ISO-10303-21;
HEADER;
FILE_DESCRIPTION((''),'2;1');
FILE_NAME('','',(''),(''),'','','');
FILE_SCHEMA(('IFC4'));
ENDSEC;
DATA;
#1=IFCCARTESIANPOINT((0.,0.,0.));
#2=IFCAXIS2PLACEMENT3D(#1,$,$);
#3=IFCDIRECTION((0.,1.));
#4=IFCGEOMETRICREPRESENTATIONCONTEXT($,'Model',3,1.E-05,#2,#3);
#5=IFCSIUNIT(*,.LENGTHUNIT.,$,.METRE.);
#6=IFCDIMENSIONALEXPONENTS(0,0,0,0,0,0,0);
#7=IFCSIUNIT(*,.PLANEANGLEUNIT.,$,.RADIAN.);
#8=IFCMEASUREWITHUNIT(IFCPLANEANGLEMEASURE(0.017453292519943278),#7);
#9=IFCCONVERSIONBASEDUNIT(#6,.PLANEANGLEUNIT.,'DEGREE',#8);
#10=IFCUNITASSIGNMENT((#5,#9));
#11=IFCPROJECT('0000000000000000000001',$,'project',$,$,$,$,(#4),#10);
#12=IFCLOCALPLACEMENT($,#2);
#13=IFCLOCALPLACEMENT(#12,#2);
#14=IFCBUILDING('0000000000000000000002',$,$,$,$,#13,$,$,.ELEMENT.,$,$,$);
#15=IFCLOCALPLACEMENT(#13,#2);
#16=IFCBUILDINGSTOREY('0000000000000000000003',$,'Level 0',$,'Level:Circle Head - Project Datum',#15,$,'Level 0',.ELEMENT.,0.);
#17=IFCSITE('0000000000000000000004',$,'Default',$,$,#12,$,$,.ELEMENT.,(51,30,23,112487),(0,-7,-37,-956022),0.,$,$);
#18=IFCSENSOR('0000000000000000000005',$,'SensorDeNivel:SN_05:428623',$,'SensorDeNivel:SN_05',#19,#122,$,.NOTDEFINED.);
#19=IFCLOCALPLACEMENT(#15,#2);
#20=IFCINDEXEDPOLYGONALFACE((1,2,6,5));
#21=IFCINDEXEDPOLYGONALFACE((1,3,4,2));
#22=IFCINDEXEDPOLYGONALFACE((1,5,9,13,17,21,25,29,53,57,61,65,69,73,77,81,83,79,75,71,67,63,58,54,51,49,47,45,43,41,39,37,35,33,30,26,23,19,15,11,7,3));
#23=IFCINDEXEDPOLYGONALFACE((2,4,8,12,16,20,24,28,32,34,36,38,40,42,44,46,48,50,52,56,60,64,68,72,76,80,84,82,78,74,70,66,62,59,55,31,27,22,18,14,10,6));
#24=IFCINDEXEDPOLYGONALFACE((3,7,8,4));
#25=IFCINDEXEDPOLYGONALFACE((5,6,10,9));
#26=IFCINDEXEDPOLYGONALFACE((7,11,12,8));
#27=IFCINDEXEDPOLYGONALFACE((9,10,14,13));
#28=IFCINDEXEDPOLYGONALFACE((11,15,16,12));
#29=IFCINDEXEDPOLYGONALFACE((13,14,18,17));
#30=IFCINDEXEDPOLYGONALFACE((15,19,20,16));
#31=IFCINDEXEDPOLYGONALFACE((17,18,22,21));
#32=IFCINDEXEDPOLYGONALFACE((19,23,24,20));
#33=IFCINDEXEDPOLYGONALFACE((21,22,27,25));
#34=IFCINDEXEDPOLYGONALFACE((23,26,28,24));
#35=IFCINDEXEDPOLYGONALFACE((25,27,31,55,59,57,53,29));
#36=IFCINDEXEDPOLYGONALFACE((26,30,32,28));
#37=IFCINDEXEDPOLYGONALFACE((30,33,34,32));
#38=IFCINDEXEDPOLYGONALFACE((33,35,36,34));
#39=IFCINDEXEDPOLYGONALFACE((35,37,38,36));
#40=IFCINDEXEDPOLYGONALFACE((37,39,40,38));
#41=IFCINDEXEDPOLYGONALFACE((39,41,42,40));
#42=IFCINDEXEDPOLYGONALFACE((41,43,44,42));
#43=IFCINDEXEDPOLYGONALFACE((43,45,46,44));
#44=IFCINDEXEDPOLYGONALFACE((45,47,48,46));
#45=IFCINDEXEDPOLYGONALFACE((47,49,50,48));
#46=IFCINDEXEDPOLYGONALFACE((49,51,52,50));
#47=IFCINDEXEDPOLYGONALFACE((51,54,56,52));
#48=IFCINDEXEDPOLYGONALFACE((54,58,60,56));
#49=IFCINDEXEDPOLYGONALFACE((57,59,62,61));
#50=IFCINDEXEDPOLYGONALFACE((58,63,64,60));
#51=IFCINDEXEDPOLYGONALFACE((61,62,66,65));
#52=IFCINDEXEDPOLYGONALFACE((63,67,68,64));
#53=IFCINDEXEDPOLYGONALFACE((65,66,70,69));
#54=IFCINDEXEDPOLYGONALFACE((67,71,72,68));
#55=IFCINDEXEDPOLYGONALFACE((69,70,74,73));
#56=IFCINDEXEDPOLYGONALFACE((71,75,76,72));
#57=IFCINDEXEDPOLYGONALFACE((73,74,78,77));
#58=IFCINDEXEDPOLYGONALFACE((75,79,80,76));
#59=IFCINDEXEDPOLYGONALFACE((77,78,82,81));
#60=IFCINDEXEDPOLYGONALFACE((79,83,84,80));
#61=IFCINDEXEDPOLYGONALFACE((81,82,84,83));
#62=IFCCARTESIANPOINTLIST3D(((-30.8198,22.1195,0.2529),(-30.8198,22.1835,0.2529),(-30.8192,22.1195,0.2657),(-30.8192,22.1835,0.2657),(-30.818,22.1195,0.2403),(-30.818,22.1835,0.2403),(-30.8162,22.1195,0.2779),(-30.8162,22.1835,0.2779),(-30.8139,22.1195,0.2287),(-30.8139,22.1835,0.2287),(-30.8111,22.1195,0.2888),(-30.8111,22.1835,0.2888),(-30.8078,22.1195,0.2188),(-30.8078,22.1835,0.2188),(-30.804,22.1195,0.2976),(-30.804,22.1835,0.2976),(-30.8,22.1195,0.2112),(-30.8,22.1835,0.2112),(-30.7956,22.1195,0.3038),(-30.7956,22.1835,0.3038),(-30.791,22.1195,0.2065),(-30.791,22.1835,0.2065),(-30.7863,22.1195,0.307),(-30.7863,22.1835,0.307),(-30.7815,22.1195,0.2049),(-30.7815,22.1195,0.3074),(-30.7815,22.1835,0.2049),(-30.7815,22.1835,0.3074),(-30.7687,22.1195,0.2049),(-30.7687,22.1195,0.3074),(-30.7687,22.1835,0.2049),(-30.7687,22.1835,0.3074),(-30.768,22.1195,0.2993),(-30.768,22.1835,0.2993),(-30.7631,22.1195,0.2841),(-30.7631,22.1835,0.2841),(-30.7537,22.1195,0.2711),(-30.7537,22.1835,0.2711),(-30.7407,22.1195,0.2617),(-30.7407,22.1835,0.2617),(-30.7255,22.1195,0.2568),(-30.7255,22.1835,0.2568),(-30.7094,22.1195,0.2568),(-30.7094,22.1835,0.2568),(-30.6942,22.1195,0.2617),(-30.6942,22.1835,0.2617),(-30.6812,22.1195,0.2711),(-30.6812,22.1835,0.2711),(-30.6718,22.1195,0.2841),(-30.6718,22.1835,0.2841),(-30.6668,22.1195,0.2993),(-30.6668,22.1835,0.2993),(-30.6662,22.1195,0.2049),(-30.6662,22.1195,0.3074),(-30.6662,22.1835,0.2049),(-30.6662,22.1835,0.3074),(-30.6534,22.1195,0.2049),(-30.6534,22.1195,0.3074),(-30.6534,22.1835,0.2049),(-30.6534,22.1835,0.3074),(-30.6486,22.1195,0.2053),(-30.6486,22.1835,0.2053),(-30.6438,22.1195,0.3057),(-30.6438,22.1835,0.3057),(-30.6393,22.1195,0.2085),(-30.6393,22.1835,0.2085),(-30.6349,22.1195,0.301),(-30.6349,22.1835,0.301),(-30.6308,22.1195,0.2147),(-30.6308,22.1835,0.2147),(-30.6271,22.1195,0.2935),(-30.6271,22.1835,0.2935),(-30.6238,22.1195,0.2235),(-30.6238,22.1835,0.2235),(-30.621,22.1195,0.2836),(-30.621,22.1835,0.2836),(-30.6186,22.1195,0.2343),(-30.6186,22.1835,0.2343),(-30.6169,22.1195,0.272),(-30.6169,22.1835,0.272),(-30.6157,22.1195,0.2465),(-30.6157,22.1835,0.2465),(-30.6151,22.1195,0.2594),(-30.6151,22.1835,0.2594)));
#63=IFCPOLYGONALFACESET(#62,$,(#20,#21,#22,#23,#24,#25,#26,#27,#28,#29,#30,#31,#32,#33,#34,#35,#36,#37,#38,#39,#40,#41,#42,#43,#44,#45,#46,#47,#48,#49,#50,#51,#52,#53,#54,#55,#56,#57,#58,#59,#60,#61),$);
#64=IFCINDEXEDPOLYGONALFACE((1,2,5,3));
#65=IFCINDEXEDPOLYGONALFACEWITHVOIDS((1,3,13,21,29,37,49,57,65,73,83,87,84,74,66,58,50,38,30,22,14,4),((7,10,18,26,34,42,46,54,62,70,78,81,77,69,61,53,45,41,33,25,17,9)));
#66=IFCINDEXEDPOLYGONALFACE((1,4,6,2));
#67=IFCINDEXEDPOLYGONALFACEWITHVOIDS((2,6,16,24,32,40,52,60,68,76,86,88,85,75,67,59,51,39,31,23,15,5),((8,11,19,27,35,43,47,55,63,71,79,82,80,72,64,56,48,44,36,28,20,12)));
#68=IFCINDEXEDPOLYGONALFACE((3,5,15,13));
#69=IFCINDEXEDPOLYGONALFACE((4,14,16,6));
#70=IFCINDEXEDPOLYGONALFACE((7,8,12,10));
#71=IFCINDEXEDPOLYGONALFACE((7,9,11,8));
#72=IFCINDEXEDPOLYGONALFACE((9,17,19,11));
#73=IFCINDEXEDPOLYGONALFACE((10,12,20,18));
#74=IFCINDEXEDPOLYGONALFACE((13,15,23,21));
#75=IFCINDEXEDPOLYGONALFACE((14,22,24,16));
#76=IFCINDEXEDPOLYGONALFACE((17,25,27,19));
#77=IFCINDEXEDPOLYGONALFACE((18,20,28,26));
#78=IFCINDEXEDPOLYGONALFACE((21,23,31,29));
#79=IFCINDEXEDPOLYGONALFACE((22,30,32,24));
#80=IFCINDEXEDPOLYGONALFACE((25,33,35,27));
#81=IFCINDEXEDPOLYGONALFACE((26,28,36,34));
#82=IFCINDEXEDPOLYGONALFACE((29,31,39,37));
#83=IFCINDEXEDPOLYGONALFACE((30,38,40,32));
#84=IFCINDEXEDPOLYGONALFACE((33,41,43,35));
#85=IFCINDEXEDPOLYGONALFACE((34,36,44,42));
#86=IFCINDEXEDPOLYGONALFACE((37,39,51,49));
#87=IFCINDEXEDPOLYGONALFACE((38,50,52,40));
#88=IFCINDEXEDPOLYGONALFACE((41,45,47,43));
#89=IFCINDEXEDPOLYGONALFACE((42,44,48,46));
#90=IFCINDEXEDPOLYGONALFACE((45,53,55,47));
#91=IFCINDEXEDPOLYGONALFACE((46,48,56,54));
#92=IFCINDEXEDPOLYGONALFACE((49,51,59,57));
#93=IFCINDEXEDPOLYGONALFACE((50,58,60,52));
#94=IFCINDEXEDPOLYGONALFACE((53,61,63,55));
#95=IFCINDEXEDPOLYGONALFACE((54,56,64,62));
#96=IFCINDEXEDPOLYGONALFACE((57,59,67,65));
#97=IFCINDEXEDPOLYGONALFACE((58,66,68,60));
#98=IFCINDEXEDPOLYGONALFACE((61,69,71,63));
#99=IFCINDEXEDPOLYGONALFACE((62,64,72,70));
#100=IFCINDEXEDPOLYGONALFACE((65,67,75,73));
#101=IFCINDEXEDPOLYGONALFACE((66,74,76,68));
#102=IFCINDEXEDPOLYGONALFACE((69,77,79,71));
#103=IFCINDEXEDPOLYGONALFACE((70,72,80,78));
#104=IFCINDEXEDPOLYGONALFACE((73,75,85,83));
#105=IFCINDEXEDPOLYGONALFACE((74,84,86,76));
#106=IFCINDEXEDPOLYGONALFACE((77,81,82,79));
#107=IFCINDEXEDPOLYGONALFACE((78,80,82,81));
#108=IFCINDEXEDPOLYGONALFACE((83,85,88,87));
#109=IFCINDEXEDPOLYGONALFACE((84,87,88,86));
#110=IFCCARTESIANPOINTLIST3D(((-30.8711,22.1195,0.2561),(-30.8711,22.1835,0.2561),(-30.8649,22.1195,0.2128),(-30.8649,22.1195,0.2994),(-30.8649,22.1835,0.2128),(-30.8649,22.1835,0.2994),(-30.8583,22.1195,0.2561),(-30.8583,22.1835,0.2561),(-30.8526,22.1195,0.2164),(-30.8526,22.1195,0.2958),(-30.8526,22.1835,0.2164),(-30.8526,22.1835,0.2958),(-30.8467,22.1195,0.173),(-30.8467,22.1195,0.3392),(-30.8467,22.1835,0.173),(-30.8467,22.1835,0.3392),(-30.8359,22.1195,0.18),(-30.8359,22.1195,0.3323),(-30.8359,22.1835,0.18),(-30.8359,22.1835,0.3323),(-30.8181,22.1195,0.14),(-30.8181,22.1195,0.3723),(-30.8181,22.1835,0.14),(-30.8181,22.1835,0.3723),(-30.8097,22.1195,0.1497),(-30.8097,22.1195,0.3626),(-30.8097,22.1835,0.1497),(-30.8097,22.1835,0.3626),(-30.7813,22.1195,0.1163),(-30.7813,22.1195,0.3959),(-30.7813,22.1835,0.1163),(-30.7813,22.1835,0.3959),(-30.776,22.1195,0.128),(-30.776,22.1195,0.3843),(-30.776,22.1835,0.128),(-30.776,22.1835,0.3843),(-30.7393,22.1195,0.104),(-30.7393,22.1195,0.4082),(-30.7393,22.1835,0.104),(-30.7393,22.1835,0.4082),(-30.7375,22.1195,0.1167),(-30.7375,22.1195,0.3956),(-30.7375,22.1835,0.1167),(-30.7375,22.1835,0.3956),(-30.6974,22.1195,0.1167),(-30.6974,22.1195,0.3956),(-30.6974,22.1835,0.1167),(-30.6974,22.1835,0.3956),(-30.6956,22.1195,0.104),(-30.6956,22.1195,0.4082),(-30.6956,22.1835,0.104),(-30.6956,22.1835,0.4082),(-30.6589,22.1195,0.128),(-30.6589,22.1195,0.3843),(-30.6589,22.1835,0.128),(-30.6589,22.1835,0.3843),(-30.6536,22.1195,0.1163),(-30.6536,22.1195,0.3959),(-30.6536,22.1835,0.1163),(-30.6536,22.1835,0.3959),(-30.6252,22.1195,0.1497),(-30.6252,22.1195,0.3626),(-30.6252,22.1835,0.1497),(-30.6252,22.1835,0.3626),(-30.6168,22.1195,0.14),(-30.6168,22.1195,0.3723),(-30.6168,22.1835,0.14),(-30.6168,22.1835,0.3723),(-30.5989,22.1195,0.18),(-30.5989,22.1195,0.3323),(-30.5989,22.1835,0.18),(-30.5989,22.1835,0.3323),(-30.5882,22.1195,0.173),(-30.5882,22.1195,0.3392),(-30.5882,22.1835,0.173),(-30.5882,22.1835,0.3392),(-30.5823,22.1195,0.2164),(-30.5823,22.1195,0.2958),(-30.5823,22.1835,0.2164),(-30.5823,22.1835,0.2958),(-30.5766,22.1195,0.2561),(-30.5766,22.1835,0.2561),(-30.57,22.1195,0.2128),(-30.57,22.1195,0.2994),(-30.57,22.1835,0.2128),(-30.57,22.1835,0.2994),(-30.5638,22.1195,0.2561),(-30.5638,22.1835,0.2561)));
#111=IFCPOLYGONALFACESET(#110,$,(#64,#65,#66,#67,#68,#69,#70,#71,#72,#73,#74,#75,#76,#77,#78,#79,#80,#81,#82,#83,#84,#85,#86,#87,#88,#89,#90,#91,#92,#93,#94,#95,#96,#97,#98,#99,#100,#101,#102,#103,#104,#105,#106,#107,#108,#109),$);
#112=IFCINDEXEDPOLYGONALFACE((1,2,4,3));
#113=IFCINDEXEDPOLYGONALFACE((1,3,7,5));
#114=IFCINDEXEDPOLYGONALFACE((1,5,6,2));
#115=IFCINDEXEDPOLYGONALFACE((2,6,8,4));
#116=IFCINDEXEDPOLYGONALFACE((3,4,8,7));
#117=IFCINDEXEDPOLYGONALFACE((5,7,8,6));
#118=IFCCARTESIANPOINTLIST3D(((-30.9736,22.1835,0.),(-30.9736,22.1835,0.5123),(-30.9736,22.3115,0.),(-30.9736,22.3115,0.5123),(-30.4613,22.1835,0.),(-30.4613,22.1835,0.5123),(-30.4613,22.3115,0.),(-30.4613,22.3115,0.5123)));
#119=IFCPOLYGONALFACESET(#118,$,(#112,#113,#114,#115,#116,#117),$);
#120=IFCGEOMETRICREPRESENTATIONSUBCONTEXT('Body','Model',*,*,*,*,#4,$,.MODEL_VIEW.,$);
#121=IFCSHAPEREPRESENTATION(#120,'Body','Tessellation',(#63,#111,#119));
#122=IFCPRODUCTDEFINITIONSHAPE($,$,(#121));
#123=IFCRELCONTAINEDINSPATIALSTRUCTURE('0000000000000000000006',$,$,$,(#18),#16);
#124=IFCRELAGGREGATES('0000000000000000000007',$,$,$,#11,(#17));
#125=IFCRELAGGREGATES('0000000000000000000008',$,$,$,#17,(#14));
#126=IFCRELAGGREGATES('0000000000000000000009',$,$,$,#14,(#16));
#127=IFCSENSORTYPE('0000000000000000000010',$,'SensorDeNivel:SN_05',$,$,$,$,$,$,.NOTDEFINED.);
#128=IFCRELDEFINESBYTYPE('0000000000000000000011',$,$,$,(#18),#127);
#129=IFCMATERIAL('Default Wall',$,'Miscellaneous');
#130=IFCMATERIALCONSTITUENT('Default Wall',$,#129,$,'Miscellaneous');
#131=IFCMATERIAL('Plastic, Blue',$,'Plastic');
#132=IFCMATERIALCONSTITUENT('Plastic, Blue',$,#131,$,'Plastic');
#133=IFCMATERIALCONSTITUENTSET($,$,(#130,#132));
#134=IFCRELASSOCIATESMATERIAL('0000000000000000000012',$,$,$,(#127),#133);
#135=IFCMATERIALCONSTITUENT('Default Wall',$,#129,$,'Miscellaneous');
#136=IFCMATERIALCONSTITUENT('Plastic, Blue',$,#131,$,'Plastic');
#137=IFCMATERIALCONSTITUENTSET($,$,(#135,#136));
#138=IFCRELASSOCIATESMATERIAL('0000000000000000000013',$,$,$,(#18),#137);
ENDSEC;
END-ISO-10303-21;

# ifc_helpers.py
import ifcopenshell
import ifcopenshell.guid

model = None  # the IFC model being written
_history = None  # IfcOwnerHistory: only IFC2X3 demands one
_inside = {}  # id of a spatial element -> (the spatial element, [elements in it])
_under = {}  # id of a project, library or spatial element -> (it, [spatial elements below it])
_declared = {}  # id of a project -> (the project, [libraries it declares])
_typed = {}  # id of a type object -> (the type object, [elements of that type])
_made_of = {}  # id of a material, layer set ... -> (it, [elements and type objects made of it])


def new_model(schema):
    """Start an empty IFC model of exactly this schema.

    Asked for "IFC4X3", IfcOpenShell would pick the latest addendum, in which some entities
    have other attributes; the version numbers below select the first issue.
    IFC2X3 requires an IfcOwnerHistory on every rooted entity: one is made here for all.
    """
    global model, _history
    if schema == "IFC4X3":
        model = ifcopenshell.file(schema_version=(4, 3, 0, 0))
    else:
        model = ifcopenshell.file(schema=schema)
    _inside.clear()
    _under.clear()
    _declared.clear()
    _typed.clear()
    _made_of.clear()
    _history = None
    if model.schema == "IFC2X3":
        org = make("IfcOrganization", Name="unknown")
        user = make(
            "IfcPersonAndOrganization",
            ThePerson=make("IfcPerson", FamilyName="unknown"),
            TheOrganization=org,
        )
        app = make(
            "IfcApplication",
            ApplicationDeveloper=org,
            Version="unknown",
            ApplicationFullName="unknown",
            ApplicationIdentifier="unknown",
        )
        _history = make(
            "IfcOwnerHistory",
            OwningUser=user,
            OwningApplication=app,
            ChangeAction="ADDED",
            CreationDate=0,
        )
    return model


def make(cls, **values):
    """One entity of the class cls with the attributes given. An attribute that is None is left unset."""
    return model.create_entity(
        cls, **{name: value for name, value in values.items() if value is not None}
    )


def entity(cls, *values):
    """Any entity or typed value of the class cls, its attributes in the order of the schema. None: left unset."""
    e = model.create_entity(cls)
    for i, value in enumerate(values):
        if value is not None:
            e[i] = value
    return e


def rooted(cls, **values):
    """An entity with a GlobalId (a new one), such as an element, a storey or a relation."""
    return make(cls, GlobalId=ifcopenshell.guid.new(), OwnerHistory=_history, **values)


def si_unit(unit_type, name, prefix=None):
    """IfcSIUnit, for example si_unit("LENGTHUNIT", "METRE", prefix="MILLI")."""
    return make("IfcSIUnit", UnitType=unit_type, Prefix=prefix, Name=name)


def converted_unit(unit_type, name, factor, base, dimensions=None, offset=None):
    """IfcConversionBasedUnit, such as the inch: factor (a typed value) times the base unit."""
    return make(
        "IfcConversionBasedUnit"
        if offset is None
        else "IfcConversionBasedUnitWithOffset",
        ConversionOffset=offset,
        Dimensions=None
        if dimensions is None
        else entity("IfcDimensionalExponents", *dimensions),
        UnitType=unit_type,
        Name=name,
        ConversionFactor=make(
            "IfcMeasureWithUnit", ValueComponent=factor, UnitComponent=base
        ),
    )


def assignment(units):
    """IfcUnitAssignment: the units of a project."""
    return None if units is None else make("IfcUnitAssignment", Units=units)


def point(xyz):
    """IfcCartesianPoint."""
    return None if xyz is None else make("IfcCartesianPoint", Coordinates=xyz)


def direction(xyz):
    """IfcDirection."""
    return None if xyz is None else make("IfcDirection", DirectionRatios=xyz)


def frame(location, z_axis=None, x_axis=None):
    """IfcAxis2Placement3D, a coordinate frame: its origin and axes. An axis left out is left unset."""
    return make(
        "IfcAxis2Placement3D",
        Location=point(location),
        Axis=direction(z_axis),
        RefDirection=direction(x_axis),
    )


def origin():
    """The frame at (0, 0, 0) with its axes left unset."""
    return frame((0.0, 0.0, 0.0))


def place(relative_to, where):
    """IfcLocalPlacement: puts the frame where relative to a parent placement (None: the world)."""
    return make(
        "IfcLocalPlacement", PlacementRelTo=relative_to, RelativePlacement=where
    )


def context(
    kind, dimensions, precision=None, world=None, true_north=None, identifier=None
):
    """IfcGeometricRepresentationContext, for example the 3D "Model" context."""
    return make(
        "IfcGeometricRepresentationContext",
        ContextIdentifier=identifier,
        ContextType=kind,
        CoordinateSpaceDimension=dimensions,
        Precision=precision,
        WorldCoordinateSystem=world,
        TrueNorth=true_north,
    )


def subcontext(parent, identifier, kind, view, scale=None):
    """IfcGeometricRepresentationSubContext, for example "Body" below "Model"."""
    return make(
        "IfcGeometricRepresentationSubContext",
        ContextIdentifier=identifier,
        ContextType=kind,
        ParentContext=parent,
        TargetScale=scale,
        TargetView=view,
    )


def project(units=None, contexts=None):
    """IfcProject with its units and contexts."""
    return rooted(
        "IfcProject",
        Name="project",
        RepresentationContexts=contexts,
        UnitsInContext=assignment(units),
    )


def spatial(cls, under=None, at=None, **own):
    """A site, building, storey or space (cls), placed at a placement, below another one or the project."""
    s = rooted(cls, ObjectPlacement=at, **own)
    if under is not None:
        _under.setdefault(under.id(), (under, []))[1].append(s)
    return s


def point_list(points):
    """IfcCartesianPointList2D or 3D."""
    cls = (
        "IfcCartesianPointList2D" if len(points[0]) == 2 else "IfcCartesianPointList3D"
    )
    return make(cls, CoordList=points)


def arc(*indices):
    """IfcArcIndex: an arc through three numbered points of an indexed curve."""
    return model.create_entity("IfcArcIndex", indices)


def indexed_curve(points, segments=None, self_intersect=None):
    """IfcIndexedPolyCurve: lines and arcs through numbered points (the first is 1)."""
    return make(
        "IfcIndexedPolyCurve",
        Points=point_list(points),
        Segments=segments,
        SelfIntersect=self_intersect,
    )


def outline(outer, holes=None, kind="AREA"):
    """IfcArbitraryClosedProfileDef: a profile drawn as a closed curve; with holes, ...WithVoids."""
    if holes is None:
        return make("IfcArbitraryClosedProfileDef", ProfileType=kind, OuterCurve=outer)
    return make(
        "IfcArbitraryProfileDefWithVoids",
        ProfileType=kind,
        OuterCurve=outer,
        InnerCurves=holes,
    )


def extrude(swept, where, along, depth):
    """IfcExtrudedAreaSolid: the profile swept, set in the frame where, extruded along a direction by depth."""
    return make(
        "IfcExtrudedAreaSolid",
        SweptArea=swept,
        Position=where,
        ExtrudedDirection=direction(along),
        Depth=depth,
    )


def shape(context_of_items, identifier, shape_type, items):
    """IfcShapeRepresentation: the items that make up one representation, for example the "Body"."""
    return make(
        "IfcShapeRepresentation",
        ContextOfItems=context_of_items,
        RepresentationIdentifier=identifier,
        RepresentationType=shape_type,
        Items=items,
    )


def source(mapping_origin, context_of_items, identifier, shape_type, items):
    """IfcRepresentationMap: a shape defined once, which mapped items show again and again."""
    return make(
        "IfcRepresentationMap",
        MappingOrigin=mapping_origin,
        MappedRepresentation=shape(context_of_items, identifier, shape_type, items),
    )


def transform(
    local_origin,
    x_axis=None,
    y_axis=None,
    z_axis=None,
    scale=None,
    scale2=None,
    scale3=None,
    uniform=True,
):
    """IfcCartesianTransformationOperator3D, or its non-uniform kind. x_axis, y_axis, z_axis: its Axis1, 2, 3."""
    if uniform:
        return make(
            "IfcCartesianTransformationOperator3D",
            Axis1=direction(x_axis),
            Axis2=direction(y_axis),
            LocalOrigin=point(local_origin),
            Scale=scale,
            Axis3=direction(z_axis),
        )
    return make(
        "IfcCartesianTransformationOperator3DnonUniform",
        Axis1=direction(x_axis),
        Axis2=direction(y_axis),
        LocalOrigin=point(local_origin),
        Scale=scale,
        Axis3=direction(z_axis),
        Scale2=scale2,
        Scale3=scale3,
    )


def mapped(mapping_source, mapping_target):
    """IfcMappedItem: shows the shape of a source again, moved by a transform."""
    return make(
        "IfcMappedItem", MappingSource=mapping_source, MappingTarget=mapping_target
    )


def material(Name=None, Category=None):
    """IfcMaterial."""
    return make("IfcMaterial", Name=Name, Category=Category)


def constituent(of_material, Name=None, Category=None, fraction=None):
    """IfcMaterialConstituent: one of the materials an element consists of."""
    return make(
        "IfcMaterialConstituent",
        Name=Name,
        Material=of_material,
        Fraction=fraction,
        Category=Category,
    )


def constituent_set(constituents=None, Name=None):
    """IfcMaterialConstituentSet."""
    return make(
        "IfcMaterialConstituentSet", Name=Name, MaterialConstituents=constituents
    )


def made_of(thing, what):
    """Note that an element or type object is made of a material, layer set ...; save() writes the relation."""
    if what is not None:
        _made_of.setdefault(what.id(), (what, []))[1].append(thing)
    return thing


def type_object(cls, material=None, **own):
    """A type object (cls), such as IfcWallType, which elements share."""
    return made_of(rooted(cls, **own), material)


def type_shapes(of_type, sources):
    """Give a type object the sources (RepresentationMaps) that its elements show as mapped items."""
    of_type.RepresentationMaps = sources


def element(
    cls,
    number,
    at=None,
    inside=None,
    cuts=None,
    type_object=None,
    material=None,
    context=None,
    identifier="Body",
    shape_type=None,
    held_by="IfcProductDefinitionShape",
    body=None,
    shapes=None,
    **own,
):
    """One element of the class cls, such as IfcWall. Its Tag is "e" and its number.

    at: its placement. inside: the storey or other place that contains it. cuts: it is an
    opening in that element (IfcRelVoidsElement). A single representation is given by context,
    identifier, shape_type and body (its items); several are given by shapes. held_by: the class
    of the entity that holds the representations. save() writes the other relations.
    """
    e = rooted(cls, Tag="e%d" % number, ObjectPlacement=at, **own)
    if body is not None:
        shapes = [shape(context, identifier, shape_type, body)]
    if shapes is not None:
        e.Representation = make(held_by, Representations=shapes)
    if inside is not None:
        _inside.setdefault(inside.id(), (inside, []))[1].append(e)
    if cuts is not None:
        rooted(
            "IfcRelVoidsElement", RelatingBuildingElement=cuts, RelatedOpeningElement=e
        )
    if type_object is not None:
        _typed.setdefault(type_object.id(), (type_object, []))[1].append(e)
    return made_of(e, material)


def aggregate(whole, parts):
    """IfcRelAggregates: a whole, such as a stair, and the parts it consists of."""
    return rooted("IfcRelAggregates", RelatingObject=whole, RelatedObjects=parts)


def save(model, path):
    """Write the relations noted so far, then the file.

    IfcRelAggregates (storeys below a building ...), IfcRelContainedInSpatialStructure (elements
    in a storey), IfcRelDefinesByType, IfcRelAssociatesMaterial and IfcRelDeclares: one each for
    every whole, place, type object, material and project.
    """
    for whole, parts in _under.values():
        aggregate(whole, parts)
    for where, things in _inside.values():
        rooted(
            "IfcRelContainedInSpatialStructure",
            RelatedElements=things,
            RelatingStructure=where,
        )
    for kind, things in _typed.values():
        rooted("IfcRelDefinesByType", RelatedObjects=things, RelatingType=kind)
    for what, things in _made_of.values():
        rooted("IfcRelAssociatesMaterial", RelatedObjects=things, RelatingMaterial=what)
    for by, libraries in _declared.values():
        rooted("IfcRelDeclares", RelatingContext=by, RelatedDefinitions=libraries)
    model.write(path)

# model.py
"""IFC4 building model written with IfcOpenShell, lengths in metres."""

from ifc_helpers import new_model, entity, si_unit, converted_unit, direction, frame, origin, place, context, subcontext, project, spatial, arc, indexed_curve, outline, extrude, source, transform, mapped, material, constituent, constituent_set, type_object, type_shapes, element, save


model = new_model("IFC4")

# Units and contexts
model_context = context("Model", 3, precision=1e-05, world=origin(), true_north=direction((0.0, 1.0)))
body_context = subcontext(model_context, "Body", "Model", "MODEL_VIEW")
ifc_project = project(units=[si_unit("LENGTHUNIT", "METRE"), converted_unit("PLANEANGLEUNIT", "DEGREE", entity("IfcPlaneAngleMeasure", 0.017453292519943278), si_unit("PLANEANGLEUNIT", "RADIAN"), dimensions=[0, 0, 0, 0, 0, 0, 0])], contexts=[model_context])

# Site, building, storey
site_placement = place(None, origin())
site = spatial("IfcSite", under=ifc_project, at=site_placement, Name="Default", CompositionType="ELEMENT", RefLatitude=(51, 30, 23, 112487), RefLongitude=(0, -7, -37, -956022), RefElevation=0.0)
building_placement = place(site_placement, origin())
building = spatial("IfcBuilding", under=site, at=building_placement, CompositionType="ELEMENT")
storey_placement = place(building_placement, origin())
storey = spatial("IfcBuildingStorey", under=building, at=storey_placement, Name="Level 0", ObjectType="Level:Circle Head - Project Datum", LongName="Level 0", CompositionType="ELEMENT", Elevation=0.0)

# Sensor
ifc_material_1 = material(Name="Default Wall", Category="Miscellaneous")
ifc_material_2 = material(Name="Plastic, Blue", Category="Plastic")
ifc_constituent_1 = constituent(ifc_material_1, Name="Default Wall", Category="Miscellaneous")
ifc_constituent_2 = constituent(ifc_material_2, Name="Plastic, Blue", Category="Plastic")
ifc_constituent_set_1 = constituent_set(constituents=[ifc_constituent_1, ifc_constituent_2])
ifc_constituent_3 = constituent(ifc_material_1, Name="Default Wall", Category="Miscellaneous")
ifc_constituent_4 = constituent(ifc_material_2, Name="Plastic, Blue", Category="Plastic")
ifc_constituent_set_2 = constituent_set(constituents=[ifc_constituent_3, ifc_constituent_4])
sensor_type_1 = type_object("IfcSensorType", Name="SensorDeNivel:SN_05", PredefinedType="NOTDEFINED", material=ifc_constituent_set_2)
shared_shape_1 = source(origin(), body_context, "Body", "SweptSolid", [
    extrude(outline(indexed_curve([(0.0512, -0.0556), (0.064, -0.0556), (0.0736, -0.054), (0.0825, -0.0493), (0.0903, -0.0417), (0.0965, -0.0318), (0.1006, -0.0202), (0.1024, -0.0076), (0.1018, 0.0052), (0.0988, 0.0174), (0.0936, 0.0283), (0.0866, 0.037), (0.0782, 0.0432), (0.0689, 0.0464), (0.064, 0.0468), (0.0512, 0.0468), (0.0506, 0.0388), (0.0456, 0.0236), (0.0362, 0.0106), (0.0233, 0.0012), (0.008, -0.0038), (-0.008, -0.0038), (-0.0233, 0.0012), (-0.0362, 0.0106), (-0.0456, 0.0236), (-0.0506, 0.0388), (-0.0512, 0.0468), (-0.064, 0.0468), (-0.0736, 0.0452), (-0.0825, 0.0405), (-0.0903, 0.0329), (-0.0965, 0.023), (-0.1006, 0.0114), (-0.1024, -0.0012), (-0.1018, -0.014), (-0.0988, -0.0262), (-0.0936, -0.0371), (-0.0866, -0.0458), (-0.0782, -0.052), (-0.0689, -0.0552), (-0.064, -0.0556), (-0.0512, -0.0556), (0.0512, -0.0556)], self_intersect=False)), frame((0.0, -0.1281, 0.2605), z_axis=(0.0, 1.0, 0.0), x_axis=(-1.0, 0.0, 0.0)), (0.0, 0.0, 1.0), 0.064),
    extrude(outline(indexed_curve([(-0.1537, 0.0), (0.0, -0.1537), (0.1537, 0.0), (0.0, 0.1537)], segments=[arc(1, 2, 3), arc(3, 4, 1)], self_intersect=False), holes=[indexed_curve([(-0.1409, 0.0), (0.0, 0.1409), (0.1409, 0.0), (0.0, -0.1409)], segments=[arc(1, 2, 3), arc(3, 4, 1)], self_intersect=False)]), frame((0.0, -0.1281, 0.2561), z_axis=(0.0, 1.0, 0.0), x_axis=(1.0, 0.0, 0.0)), (0.0, 0.0, 1.0), 0.064),
    extrude(outline(indexed_curve([(-0.2561, -0.064), (0.2561, -0.064), (0.2561, 0.064), (-0.2561, 0.064), (-0.2561, -0.064)], self_intersect=False)), frame((0.0, 0.0, 0.0), z_axis=(0.0, 0.0, 1.0), x_axis=(-1.0, 0.0, 0.0)), (0.0, 0.0, 1.0), 0.5123),
])
type_shapes(sensor_type_1, [shared_shape_1])
sensor_1_placement = place(storey_placement, frame((-30.7174, 22.2475, 0.0)))
element("IfcSensor", 1, at=sensor_1_placement, inside=storey, type_object=sensor_type_1, material=ifc_constituent_set_1, Name="SensorDeNivel:SN_05:428623", ObjectType="SensorDeNivel:SN_05", PredefinedType="NOTDEFINED", context=body_context, shape_type="MappedRepresentation", body=[
    mapped(shared_shape_1, transform((0.0, 0.0, 0.0), scale=1.0)),
])

save(model, "model.ifc")
